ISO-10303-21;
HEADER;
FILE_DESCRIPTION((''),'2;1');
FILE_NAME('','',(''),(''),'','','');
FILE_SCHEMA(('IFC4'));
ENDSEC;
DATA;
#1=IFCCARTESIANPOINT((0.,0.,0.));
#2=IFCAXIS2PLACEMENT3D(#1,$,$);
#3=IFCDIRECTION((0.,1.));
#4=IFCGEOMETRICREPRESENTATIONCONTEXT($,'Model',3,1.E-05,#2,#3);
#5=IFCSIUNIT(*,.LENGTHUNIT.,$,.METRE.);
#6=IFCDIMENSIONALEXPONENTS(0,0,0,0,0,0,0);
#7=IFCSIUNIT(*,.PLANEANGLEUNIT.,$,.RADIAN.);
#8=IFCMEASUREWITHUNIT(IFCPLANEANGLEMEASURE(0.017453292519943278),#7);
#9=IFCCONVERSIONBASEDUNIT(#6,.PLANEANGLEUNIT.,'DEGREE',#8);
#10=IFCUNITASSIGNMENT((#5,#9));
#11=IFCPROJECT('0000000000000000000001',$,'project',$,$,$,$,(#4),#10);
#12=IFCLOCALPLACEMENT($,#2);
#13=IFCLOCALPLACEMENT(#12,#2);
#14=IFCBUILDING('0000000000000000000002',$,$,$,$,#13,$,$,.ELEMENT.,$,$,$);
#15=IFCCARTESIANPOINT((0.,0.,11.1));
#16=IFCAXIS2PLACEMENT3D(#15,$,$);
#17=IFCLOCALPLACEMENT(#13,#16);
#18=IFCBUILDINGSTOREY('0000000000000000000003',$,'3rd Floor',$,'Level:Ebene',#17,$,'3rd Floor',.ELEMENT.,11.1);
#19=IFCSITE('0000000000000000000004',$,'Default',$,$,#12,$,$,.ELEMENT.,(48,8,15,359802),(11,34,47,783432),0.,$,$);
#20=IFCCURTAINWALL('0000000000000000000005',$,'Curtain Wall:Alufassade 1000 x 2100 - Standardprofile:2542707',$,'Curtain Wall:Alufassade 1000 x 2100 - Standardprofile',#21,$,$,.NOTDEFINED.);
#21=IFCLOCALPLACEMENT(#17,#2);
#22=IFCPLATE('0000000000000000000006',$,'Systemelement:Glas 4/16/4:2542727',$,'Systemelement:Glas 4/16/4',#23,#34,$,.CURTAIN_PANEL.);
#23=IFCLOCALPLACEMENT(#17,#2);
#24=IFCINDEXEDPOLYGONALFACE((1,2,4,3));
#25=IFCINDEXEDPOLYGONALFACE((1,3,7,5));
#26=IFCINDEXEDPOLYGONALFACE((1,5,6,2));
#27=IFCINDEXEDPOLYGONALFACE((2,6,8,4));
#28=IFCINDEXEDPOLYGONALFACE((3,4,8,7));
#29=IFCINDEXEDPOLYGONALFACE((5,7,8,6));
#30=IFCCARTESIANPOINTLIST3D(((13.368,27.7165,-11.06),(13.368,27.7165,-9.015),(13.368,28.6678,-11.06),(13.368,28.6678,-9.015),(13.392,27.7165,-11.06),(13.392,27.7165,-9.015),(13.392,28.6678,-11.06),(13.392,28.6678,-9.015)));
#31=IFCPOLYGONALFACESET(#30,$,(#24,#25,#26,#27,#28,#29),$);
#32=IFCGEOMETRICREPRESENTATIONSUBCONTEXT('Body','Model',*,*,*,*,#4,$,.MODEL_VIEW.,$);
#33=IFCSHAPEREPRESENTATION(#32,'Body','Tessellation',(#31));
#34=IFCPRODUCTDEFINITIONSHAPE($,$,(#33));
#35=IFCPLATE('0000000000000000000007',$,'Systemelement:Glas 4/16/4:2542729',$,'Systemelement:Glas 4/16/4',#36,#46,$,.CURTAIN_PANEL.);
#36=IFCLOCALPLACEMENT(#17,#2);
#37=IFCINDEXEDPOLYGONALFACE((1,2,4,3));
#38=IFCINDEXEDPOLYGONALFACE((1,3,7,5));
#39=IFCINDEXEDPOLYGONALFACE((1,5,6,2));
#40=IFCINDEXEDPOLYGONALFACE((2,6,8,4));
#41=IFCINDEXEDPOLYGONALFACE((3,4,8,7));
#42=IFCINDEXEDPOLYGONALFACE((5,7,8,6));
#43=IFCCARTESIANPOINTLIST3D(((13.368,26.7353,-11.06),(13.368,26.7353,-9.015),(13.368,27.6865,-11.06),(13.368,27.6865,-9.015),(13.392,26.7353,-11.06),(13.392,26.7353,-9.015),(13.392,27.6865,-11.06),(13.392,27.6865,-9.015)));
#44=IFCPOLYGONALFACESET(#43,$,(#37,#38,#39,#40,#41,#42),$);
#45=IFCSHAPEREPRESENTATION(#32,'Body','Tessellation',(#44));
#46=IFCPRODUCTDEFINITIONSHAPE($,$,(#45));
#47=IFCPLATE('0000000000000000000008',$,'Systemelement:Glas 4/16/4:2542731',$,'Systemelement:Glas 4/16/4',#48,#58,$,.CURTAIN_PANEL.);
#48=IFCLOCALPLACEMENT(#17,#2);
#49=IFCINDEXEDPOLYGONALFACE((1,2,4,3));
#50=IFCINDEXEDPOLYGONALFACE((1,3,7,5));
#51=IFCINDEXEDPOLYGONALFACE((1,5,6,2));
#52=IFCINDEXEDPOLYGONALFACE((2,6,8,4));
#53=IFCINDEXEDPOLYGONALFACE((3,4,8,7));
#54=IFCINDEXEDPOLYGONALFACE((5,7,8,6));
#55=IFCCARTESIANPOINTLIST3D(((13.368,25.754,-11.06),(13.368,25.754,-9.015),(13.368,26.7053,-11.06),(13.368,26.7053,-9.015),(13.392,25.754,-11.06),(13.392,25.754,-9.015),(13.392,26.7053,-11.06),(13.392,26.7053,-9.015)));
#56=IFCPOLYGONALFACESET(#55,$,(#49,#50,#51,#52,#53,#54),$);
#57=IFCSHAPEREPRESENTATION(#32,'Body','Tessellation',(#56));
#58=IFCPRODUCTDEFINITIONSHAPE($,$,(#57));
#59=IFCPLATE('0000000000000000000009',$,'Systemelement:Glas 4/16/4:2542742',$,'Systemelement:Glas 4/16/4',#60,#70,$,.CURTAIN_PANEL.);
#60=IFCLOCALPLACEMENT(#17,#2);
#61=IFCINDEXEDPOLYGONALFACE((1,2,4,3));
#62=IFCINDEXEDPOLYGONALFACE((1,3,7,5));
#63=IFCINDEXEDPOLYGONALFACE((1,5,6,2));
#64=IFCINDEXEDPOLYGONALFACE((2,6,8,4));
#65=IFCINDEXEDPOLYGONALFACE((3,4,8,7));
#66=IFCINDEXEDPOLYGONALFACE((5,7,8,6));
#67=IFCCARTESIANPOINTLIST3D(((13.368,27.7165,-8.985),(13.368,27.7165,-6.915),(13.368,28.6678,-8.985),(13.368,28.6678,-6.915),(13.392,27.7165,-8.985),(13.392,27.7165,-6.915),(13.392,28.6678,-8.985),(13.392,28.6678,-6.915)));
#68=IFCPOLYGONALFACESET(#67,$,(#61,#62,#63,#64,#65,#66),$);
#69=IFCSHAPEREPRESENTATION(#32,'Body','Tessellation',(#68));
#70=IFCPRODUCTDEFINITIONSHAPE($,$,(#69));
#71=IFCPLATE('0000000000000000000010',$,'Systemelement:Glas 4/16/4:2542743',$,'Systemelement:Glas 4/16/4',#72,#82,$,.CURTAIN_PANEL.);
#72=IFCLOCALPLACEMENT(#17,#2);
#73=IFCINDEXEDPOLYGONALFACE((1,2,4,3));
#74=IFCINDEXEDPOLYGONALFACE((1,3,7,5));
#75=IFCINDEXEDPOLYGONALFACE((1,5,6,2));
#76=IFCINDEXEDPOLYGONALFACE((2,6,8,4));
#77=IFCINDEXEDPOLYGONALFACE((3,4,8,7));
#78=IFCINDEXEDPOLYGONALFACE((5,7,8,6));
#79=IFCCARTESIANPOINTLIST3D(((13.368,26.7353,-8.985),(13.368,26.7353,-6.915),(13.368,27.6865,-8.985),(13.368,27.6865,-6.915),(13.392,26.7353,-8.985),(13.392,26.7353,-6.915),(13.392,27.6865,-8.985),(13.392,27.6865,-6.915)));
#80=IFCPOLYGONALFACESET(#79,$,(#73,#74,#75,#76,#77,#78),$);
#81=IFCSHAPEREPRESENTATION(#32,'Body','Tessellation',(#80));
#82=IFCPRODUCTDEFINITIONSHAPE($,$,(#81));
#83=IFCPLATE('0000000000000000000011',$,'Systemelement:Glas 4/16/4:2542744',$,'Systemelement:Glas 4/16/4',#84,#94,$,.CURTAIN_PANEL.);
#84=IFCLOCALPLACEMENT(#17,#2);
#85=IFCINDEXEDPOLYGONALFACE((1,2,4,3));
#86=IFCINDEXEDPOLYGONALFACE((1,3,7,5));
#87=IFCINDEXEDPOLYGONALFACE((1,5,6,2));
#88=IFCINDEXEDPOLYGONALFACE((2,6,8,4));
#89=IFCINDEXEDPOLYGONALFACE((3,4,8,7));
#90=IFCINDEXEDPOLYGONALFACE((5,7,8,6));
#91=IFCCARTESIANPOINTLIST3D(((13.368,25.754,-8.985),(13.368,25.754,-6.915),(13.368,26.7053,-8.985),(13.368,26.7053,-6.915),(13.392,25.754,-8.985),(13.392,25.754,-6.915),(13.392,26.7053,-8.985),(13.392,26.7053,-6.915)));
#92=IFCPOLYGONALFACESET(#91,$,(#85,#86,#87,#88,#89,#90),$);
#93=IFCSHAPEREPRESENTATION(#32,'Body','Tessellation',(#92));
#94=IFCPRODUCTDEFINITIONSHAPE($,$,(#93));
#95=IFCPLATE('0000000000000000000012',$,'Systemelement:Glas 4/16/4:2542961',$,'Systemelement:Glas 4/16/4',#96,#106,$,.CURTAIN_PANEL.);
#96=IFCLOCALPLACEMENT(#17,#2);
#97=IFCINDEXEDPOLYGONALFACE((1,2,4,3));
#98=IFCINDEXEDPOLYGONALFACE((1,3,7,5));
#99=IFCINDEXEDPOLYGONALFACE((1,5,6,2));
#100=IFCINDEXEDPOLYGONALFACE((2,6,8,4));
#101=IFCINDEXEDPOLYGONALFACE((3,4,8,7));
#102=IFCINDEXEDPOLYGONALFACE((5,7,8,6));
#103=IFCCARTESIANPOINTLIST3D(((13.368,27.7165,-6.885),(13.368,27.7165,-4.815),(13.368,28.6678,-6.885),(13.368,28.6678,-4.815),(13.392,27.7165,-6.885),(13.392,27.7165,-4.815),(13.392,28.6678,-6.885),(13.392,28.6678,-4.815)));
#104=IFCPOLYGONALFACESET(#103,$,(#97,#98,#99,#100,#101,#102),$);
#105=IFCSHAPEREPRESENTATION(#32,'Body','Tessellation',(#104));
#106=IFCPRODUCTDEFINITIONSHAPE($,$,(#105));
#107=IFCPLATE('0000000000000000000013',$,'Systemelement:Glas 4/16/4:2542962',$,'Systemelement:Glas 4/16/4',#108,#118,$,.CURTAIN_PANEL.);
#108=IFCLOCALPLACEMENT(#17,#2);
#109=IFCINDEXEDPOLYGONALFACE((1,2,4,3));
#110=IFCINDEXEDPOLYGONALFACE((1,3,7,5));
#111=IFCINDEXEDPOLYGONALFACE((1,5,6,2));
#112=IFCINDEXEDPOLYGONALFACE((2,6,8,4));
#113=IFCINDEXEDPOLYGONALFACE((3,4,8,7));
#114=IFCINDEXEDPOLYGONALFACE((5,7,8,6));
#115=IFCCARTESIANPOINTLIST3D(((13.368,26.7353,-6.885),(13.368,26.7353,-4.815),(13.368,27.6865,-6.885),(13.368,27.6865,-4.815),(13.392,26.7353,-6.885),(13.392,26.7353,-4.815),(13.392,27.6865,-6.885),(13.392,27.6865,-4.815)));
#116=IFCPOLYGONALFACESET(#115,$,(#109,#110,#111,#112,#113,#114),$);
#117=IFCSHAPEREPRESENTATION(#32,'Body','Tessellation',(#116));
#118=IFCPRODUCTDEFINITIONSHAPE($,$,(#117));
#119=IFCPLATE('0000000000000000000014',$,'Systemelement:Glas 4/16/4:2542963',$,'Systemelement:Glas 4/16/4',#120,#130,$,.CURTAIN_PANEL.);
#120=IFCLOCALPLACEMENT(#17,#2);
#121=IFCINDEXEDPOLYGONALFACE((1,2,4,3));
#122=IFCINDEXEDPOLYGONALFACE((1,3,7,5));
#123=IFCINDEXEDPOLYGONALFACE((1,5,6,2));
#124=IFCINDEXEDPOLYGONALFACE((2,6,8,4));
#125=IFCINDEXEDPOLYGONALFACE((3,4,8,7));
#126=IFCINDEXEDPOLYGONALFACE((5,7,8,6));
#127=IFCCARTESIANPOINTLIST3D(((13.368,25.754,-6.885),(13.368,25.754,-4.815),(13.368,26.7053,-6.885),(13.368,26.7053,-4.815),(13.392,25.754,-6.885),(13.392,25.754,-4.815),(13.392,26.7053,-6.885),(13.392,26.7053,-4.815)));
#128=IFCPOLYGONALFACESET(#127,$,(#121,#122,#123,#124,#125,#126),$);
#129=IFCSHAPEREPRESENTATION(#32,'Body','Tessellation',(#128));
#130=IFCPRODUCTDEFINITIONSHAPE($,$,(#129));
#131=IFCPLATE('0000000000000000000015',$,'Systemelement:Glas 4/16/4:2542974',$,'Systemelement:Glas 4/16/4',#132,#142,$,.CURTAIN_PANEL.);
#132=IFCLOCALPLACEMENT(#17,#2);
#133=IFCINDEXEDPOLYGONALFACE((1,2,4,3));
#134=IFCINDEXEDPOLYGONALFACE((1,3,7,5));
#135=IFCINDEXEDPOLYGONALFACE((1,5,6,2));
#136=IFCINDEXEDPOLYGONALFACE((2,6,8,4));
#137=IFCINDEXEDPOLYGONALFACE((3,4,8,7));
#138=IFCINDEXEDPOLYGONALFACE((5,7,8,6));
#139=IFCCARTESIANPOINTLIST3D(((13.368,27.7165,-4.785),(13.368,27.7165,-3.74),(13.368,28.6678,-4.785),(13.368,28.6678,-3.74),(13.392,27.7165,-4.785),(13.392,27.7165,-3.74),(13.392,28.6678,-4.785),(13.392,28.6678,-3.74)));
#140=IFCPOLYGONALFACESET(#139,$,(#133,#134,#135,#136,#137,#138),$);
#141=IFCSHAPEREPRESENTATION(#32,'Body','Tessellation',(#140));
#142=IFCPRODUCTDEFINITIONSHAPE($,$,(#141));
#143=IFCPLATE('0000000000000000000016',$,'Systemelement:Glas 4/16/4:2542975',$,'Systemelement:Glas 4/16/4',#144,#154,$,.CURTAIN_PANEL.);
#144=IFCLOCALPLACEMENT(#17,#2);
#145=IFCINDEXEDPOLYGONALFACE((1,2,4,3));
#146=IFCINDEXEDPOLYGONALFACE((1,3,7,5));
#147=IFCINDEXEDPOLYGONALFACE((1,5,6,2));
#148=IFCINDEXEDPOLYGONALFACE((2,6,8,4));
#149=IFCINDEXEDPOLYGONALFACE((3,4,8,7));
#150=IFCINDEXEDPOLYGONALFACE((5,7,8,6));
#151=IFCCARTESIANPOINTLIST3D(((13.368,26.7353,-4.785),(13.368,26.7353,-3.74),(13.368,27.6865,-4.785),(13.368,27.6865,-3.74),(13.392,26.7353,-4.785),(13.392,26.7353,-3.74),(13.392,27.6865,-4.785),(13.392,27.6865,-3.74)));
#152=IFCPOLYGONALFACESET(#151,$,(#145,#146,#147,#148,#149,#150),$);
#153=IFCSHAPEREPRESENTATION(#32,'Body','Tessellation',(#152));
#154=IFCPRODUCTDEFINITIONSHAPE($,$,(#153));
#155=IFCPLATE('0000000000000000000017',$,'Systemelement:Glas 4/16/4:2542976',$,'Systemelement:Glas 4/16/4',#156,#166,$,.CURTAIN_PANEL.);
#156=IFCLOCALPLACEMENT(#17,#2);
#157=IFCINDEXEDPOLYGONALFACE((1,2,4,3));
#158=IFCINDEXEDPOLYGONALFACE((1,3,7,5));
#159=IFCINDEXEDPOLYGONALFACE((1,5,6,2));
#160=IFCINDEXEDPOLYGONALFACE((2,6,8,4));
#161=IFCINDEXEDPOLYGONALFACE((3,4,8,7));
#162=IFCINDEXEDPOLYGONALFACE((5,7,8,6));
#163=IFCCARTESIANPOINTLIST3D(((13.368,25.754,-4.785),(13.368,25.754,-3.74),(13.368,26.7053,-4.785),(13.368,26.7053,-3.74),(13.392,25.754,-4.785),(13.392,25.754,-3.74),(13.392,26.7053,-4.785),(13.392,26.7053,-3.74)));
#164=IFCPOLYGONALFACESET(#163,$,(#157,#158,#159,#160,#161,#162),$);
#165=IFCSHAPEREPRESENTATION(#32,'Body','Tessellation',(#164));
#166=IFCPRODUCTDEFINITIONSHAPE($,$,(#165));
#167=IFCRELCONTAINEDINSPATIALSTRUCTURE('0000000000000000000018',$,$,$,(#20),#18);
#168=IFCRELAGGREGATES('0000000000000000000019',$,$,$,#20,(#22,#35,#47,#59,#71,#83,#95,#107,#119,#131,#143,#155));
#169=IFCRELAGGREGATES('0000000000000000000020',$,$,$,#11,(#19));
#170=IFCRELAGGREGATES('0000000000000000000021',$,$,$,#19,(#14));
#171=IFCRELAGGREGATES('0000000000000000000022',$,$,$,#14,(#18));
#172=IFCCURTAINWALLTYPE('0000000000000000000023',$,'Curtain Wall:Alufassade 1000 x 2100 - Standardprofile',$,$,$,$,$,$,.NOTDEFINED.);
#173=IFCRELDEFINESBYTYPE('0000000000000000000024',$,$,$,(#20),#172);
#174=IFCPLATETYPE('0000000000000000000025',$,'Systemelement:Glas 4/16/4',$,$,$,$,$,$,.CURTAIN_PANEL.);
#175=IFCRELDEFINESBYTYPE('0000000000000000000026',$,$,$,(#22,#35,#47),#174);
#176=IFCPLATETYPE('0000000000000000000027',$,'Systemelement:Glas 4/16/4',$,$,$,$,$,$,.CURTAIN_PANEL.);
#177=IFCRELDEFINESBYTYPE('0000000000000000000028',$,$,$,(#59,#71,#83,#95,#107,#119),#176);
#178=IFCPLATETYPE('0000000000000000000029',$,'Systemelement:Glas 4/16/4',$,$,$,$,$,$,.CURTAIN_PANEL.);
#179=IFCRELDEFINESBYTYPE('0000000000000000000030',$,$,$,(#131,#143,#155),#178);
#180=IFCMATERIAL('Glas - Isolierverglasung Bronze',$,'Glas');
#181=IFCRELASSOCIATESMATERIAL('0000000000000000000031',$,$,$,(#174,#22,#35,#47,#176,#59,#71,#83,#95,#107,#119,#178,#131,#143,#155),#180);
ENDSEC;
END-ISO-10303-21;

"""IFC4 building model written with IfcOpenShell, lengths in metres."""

from ifc_helpers import new_model, entity, si_unit, converted_unit, direction, frame, origin, place, context, subcontext, project, spatial, indexed_curve, outline, extrude, source, transform, mapped, material, type_object, type_shapes, element, aggregate, save


model = new_model("IFC4")

# Units and contexts
model_context = context("Model", 3, precision=1e-05, world=origin(), true_north=direction((0.0, 1.0)))
body_context = subcontext(model_context, "Body", "Model", "MODEL_VIEW")
ifc_project = project(units=[si_unit("LENGTHUNIT", "METRE"), converted_unit("PLANEANGLEUNIT", "DEGREE", entity("IfcPlaneAngleMeasure", 0.017453292519943278), si_unit("PLANEANGLEUNIT", "RADIAN"), dimensions=[0, 0, 0, 0, 0, 0, 0])], contexts=[model_context])

# Site, building, storey
site_placement = place(None, origin())
site = spatial("IfcSite", under=ifc_project, at=site_placement, Name="Default", CompositionType="ELEMENT", RefLatitude=(48, 8, 15, 359802), RefLongitude=(11, 34, 47, 783432), RefElevation=0.0)
building_placement = place(site_placement, origin())
building = spatial("IfcBuilding", under=site, at=building_placement, CompositionType="ELEMENT")
storey_placement = place(building_placement, frame((0.0, 0.0, 11.1)))
storey = spatial("IfcBuildingStorey", under=building, at=storey_placement, Name="3rd Floor", ObjectType="Level:Ebene", LongName="3rd Floor", CompositionType="ELEMENT", Elevation=11.1)

# Curtain wall, plates
curtain_wall_type = type_object("IfcCurtainWallType", Name="Curtain Wall:Alufassade 1000 x 2100 - Standardprofile", PredefinedType="NOTDEFINED")
curtain_wall_placement = place(storey_placement, frame((0.0, 0.0, -11.1)))
curtain_wall = element("IfcCurtainWall", 1, at=curtain_wall_placement, inside=storey, type_object=curtain_wall_type, Name="Curtain Wall:Alufassade 1000 x 2100 - Standardprofile:2542707", ObjectType="Curtain Wall:Alufassade 1000 x 2100 - Standardprofile", PredefinedType="NOTDEFINED")
ifc_material_1 = material(Name="Glas - Isolierverglasung Bronze", Category="Glas")
plate_type_1 = type_object("IfcPlateType", Name="Systemelement:Glas 4/16/4", PredefinedType="CURTAIN_PANEL", material=ifc_material_1)
shared_shape_1 = source(origin(), body_context, "Body", "SweptSolid", [
    extrude(outline(indexed_curve([(-0.012, -0.4756), (0.012, -0.4756), (0.012, 0.4756), (-0.012, 0.4756), (-0.012, -0.4756)], self_intersect=False)), frame((0.0, 0.0, 0.0), z_axis=(0.0, 0.0, 1.0), x_axis=(0.0, 1.0, 0.0)), (0.0, 0.0, 1.0), 2.045),
])
type_shapes(plate_type_1, [shared_shape_1])
plate_1_placement = place(curtain_wall_placement, frame((13.38, 28.1921, 0.04), z_axis=(0.0, 0.0, 1.0), x_axis=(0.0, -1.0, 0.0)))
plate_1 = element("IfcPlate", 2, at=plate_1_placement, type_object=plate_type_1, material=ifc_material_1, Name="Systemelement:Glas 4/16/4:2542727", ObjectType="Systemelement:Glas 4/16/4", PredefinedType="CURTAIN_PANEL", context=body_context, shape_type="MappedRepresentation", body=[
    mapped(shared_shape_1, transform((0.0, 0.0, 0.0), scale=1.0)),
])
plate_2_placement = place(curtain_wall_placement, frame((13.38, 27.2109, 0.04), z_axis=(0.0, 0.0, 1.0), x_axis=(0.0, -1.0, 0.0)))
plate_2 = element("IfcPlate", 3, at=plate_2_placement, type_object=plate_type_1, material=ifc_material_1, Name="Systemelement:Glas 4/16/4:2542729", ObjectType="Systemelement:Glas 4/16/4", PredefinedType="CURTAIN_PANEL", context=body_context, shape_type="MappedRepresentation", body=[
    mapped(shared_shape_1, transform((0.0, 0.0, 0.0), scale=1.0)),
])
plate_3_placement = place(curtain_wall_placement, frame((13.38, 26.2296, 0.04), z_axis=(0.0, 0.0, 1.0), x_axis=(0.0, -1.0, 0.0)))
plate_3 = element("IfcPlate", 4, at=plate_3_placement, type_object=plate_type_1, material=ifc_material_1, Name="Systemelement:Glas 4/16/4:2542731", ObjectType="Systemelement:Glas 4/16/4", PredefinedType="CURTAIN_PANEL", context=body_context, shape_type="MappedRepresentation", body=[
    mapped(shared_shape_1, transform((0.0, 0.0, 0.0), scale=1.0)),
])
plate_type_2 = type_object("IfcPlateType", Name="Systemelement:Glas 4/16/4", PredefinedType="CURTAIN_PANEL", material=ifc_material_1)
shared_shape_2 = source(origin(), body_context, "Body", "SweptSolid", [
    extrude(outline(indexed_curve([(-0.012, -0.4756), (0.012, -0.4756), (0.012, 0.4756), (-0.012, 0.4756), (-0.012, -0.4756)], self_intersect=False)), frame((0.0, 0.0, 0.0), z_axis=(0.0, 0.0, 1.0), x_axis=(0.0, 1.0, 0.0)), (0.0, 0.0, 1.0), 2.07),
])
type_shapes(plate_type_2, [shared_shape_2])
plate_4_placement = place(curtain_wall_placement, frame((13.38, 28.1921, 2.115), z_axis=(0.0, 0.0, 1.0), x_axis=(0.0, -1.0, 0.0)))
plate_4 = element("IfcPlate", 5, at=plate_4_placement, type_object=plate_type_2, material=ifc_material_1, Name="Systemelement:Glas 4/16/4:2542742", ObjectType="Systemelement:Glas 4/16/4", PredefinedType="CURTAIN_PANEL", context=body_context, shape_type="MappedRepresentation", body=[
    mapped(shared_shape_2, transform((0.0, 0.0, 0.0), scale=1.0)),
])
plate_5_placement = place(curtain_wall_placement, frame((13.38, 27.2109, 2.115), z_axis=(0.0, 0.0, 1.0), x_axis=(0.0, -1.0, 0.0)))
plate_5 = element("IfcPlate", 6, at=plate_5_placement, type_object=plate_type_2, material=ifc_material_1, Name="Systemelement:Glas 4/16/4:2542743", ObjectType="Systemelement:Glas 4/16/4", PredefinedType="CURTAIN_PANEL", context=body_context, shape_type="MappedRepresentation", body=[
    mapped(shared_shape_2, transform((0.0, 0.0, 0.0), scale=1.0)),
])
plate_6_placement = place(curtain_wall_placement, frame((13.38, 26.2296, 2.115), z_axis=(0.0, 0.0, 1.0), x_axis=(0.0, -1.0, 0.0)))
plate_6 = element("IfcPlate", 7, at=plate_6_placement, type_object=plate_type_2, material=ifc_material_1, Name="Systemelement:Glas 4/16/4:2542744", ObjectType="Systemelement:Glas 4/16/4", PredefinedType="CURTAIN_PANEL", context=body_context, shape_type="MappedRepresentation", body=[
    mapped(shared_shape_2, transform((0.0, 0.0, 0.0), scale=1.0)),
])
plate_7_placement = place(curtain_wall_placement, frame((13.38, 28.1921, 4.215), z_axis=(0.0, 0.0, 1.0), x_axis=(0.0, -1.0, 0.0)))
plate_7 = element("IfcPlate", 8, at=plate_7_placement, type_object=plate_type_2, material=ifc_material_1, Name="Systemelement:Glas 4/16/4:2542961", ObjectType="Systemelement:Glas 4/16/4", PredefinedType="CURTAIN_PANEL", context=body_context, shape_type="MappedRepresentation", body=[
    mapped(shared_shape_2, transform((0.0, 0.0, 0.0), scale=1.0)),
])
plate_8_placement = place(curtain_wall_placement, frame((13.38, 27.2109, 4.215), z_axis=(0.0, 0.0, 1.0), x_axis=(0.0, -1.0, 0.0)))
plate_8 = element("IfcPlate", 9, at=plate_8_placement, type_object=plate_type_2, material=ifc_material_1, Name="Systemelement:Glas 4/16/4:2542962", ObjectType="Systemelement:Glas 4/16/4", PredefinedType="CURTAIN_PANEL", context=body_context, shape_type="MappedRepresentation", body=[
    mapped(shared_shape_2, transform((0.0, 0.0, 0.0), scale=1.0)),
])
plate_9_placement = place(curtain_wall_placement, frame((13.38, 26.2296, 4.215), z_axis=(0.0, 0.0, 1.0), x_axis=(0.0, -1.0, 0.0)))
plate_9 = element("IfcPlate", 10, at=plate_9_placement, type_object=plate_type_2, material=ifc_material_1, Name="Systemelement:Glas 4/16/4:2542963", ObjectType="Systemelement:Glas 4/16/4", PredefinedType="CURTAIN_PANEL", context=body_context, shape_type="MappedRepresentation", body=[
    mapped(shared_shape_2, transform((0.0, 0.0, 0.0), scale=1.0)),
])
plate_type_3 = type_object("IfcPlateType", Name="Systemelement:Glas 4/16/4", PredefinedType="CURTAIN_PANEL", material=ifc_material_1)
shared_shape_3 = source(origin(), body_context, "Body", "SweptSolid", [
    extrude(outline(indexed_curve([(-0.012, -0.4756), (0.012, -0.4756), (0.012, 0.4756), (-0.012, 0.4756), (-0.012, -0.4756)], self_intersect=False)), frame((0.0, 0.0, 0.0), z_axis=(0.0, 0.0, 1.0), x_axis=(0.0, 1.0, 0.0)), (0.0, 0.0, 1.0), 1.045),
])
type_shapes(plate_type_3, [shared_shape_3])
plate_10_placement = place(curtain_wall_placement, frame((13.38, 28.1921, 6.315), z_axis=(0.0, 0.0, 1.0), x_axis=(0.0, -1.0, 0.0)))
plate_10 = element("IfcPlate", 11, at=plate_10_placement, type_object=plate_type_3, material=ifc_material_1, Name="Systemelement:Glas 4/16/4:2542974", ObjectType="Systemelement:Glas 4/16/4", PredefinedType="CURTAIN_PANEL", context=body_context, shape_type="MappedRepresentation", body=[
    mapped(shared_shape_3, transform((0.0, 0.0, 0.0), scale=1.0)),
])
plate_11_placement = place(curtain_wall_placement, frame((13.38, 27.2109, 6.315), z_axis=(0.0, 0.0, 1.0), x_axis=(0.0, -1.0, 0.0)))
plate_11 = element("IfcPlate", 12, at=plate_11_placement, type_object=plate_type_3, material=ifc_material_1, Name="Systemelement:Glas 4/16/4:2542975", ObjectType="Systemelement:Glas 4/16/4", PredefinedType="CURTAIN_PANEL", context=body_context, shape_type="MappedRepresentation", body=[
    mapped(shared_shape_3, transform((0.0, 0.0, 0.0), scale=1.0)),
])
plate_12_placement = place(curtain_wall_placement, frame((13.38, 26.2296, 6.315), z_axis=(0.0, 0.0, 1.0), x_axis=(0.0, -1.0, 0.0)))
plate_12 = element("IfcPlate", 13, at=plate_12_placement, type_object=plate_type_3, material=ifc_material_1, Name="Systemelement:Glas 4/16/4:2542976", ObjectType="Systemelement:Glas 4/16/4", PredefinedType="CURTAIN_PANEL", context=body_context, shape_type="MappedRepresentation", body=[
    mapped(shared_shape_3, transform((0.0, 0.0, 0.0), scale=1.0)),
])
aggregate(curtain_wall, [plate_1, plate_2, plate_3, plate_4, plate_5, plate_6, plate_7, plate_8, plate_9, plate_10, plate_11, plate_12])

save(model, "model.ifc")
